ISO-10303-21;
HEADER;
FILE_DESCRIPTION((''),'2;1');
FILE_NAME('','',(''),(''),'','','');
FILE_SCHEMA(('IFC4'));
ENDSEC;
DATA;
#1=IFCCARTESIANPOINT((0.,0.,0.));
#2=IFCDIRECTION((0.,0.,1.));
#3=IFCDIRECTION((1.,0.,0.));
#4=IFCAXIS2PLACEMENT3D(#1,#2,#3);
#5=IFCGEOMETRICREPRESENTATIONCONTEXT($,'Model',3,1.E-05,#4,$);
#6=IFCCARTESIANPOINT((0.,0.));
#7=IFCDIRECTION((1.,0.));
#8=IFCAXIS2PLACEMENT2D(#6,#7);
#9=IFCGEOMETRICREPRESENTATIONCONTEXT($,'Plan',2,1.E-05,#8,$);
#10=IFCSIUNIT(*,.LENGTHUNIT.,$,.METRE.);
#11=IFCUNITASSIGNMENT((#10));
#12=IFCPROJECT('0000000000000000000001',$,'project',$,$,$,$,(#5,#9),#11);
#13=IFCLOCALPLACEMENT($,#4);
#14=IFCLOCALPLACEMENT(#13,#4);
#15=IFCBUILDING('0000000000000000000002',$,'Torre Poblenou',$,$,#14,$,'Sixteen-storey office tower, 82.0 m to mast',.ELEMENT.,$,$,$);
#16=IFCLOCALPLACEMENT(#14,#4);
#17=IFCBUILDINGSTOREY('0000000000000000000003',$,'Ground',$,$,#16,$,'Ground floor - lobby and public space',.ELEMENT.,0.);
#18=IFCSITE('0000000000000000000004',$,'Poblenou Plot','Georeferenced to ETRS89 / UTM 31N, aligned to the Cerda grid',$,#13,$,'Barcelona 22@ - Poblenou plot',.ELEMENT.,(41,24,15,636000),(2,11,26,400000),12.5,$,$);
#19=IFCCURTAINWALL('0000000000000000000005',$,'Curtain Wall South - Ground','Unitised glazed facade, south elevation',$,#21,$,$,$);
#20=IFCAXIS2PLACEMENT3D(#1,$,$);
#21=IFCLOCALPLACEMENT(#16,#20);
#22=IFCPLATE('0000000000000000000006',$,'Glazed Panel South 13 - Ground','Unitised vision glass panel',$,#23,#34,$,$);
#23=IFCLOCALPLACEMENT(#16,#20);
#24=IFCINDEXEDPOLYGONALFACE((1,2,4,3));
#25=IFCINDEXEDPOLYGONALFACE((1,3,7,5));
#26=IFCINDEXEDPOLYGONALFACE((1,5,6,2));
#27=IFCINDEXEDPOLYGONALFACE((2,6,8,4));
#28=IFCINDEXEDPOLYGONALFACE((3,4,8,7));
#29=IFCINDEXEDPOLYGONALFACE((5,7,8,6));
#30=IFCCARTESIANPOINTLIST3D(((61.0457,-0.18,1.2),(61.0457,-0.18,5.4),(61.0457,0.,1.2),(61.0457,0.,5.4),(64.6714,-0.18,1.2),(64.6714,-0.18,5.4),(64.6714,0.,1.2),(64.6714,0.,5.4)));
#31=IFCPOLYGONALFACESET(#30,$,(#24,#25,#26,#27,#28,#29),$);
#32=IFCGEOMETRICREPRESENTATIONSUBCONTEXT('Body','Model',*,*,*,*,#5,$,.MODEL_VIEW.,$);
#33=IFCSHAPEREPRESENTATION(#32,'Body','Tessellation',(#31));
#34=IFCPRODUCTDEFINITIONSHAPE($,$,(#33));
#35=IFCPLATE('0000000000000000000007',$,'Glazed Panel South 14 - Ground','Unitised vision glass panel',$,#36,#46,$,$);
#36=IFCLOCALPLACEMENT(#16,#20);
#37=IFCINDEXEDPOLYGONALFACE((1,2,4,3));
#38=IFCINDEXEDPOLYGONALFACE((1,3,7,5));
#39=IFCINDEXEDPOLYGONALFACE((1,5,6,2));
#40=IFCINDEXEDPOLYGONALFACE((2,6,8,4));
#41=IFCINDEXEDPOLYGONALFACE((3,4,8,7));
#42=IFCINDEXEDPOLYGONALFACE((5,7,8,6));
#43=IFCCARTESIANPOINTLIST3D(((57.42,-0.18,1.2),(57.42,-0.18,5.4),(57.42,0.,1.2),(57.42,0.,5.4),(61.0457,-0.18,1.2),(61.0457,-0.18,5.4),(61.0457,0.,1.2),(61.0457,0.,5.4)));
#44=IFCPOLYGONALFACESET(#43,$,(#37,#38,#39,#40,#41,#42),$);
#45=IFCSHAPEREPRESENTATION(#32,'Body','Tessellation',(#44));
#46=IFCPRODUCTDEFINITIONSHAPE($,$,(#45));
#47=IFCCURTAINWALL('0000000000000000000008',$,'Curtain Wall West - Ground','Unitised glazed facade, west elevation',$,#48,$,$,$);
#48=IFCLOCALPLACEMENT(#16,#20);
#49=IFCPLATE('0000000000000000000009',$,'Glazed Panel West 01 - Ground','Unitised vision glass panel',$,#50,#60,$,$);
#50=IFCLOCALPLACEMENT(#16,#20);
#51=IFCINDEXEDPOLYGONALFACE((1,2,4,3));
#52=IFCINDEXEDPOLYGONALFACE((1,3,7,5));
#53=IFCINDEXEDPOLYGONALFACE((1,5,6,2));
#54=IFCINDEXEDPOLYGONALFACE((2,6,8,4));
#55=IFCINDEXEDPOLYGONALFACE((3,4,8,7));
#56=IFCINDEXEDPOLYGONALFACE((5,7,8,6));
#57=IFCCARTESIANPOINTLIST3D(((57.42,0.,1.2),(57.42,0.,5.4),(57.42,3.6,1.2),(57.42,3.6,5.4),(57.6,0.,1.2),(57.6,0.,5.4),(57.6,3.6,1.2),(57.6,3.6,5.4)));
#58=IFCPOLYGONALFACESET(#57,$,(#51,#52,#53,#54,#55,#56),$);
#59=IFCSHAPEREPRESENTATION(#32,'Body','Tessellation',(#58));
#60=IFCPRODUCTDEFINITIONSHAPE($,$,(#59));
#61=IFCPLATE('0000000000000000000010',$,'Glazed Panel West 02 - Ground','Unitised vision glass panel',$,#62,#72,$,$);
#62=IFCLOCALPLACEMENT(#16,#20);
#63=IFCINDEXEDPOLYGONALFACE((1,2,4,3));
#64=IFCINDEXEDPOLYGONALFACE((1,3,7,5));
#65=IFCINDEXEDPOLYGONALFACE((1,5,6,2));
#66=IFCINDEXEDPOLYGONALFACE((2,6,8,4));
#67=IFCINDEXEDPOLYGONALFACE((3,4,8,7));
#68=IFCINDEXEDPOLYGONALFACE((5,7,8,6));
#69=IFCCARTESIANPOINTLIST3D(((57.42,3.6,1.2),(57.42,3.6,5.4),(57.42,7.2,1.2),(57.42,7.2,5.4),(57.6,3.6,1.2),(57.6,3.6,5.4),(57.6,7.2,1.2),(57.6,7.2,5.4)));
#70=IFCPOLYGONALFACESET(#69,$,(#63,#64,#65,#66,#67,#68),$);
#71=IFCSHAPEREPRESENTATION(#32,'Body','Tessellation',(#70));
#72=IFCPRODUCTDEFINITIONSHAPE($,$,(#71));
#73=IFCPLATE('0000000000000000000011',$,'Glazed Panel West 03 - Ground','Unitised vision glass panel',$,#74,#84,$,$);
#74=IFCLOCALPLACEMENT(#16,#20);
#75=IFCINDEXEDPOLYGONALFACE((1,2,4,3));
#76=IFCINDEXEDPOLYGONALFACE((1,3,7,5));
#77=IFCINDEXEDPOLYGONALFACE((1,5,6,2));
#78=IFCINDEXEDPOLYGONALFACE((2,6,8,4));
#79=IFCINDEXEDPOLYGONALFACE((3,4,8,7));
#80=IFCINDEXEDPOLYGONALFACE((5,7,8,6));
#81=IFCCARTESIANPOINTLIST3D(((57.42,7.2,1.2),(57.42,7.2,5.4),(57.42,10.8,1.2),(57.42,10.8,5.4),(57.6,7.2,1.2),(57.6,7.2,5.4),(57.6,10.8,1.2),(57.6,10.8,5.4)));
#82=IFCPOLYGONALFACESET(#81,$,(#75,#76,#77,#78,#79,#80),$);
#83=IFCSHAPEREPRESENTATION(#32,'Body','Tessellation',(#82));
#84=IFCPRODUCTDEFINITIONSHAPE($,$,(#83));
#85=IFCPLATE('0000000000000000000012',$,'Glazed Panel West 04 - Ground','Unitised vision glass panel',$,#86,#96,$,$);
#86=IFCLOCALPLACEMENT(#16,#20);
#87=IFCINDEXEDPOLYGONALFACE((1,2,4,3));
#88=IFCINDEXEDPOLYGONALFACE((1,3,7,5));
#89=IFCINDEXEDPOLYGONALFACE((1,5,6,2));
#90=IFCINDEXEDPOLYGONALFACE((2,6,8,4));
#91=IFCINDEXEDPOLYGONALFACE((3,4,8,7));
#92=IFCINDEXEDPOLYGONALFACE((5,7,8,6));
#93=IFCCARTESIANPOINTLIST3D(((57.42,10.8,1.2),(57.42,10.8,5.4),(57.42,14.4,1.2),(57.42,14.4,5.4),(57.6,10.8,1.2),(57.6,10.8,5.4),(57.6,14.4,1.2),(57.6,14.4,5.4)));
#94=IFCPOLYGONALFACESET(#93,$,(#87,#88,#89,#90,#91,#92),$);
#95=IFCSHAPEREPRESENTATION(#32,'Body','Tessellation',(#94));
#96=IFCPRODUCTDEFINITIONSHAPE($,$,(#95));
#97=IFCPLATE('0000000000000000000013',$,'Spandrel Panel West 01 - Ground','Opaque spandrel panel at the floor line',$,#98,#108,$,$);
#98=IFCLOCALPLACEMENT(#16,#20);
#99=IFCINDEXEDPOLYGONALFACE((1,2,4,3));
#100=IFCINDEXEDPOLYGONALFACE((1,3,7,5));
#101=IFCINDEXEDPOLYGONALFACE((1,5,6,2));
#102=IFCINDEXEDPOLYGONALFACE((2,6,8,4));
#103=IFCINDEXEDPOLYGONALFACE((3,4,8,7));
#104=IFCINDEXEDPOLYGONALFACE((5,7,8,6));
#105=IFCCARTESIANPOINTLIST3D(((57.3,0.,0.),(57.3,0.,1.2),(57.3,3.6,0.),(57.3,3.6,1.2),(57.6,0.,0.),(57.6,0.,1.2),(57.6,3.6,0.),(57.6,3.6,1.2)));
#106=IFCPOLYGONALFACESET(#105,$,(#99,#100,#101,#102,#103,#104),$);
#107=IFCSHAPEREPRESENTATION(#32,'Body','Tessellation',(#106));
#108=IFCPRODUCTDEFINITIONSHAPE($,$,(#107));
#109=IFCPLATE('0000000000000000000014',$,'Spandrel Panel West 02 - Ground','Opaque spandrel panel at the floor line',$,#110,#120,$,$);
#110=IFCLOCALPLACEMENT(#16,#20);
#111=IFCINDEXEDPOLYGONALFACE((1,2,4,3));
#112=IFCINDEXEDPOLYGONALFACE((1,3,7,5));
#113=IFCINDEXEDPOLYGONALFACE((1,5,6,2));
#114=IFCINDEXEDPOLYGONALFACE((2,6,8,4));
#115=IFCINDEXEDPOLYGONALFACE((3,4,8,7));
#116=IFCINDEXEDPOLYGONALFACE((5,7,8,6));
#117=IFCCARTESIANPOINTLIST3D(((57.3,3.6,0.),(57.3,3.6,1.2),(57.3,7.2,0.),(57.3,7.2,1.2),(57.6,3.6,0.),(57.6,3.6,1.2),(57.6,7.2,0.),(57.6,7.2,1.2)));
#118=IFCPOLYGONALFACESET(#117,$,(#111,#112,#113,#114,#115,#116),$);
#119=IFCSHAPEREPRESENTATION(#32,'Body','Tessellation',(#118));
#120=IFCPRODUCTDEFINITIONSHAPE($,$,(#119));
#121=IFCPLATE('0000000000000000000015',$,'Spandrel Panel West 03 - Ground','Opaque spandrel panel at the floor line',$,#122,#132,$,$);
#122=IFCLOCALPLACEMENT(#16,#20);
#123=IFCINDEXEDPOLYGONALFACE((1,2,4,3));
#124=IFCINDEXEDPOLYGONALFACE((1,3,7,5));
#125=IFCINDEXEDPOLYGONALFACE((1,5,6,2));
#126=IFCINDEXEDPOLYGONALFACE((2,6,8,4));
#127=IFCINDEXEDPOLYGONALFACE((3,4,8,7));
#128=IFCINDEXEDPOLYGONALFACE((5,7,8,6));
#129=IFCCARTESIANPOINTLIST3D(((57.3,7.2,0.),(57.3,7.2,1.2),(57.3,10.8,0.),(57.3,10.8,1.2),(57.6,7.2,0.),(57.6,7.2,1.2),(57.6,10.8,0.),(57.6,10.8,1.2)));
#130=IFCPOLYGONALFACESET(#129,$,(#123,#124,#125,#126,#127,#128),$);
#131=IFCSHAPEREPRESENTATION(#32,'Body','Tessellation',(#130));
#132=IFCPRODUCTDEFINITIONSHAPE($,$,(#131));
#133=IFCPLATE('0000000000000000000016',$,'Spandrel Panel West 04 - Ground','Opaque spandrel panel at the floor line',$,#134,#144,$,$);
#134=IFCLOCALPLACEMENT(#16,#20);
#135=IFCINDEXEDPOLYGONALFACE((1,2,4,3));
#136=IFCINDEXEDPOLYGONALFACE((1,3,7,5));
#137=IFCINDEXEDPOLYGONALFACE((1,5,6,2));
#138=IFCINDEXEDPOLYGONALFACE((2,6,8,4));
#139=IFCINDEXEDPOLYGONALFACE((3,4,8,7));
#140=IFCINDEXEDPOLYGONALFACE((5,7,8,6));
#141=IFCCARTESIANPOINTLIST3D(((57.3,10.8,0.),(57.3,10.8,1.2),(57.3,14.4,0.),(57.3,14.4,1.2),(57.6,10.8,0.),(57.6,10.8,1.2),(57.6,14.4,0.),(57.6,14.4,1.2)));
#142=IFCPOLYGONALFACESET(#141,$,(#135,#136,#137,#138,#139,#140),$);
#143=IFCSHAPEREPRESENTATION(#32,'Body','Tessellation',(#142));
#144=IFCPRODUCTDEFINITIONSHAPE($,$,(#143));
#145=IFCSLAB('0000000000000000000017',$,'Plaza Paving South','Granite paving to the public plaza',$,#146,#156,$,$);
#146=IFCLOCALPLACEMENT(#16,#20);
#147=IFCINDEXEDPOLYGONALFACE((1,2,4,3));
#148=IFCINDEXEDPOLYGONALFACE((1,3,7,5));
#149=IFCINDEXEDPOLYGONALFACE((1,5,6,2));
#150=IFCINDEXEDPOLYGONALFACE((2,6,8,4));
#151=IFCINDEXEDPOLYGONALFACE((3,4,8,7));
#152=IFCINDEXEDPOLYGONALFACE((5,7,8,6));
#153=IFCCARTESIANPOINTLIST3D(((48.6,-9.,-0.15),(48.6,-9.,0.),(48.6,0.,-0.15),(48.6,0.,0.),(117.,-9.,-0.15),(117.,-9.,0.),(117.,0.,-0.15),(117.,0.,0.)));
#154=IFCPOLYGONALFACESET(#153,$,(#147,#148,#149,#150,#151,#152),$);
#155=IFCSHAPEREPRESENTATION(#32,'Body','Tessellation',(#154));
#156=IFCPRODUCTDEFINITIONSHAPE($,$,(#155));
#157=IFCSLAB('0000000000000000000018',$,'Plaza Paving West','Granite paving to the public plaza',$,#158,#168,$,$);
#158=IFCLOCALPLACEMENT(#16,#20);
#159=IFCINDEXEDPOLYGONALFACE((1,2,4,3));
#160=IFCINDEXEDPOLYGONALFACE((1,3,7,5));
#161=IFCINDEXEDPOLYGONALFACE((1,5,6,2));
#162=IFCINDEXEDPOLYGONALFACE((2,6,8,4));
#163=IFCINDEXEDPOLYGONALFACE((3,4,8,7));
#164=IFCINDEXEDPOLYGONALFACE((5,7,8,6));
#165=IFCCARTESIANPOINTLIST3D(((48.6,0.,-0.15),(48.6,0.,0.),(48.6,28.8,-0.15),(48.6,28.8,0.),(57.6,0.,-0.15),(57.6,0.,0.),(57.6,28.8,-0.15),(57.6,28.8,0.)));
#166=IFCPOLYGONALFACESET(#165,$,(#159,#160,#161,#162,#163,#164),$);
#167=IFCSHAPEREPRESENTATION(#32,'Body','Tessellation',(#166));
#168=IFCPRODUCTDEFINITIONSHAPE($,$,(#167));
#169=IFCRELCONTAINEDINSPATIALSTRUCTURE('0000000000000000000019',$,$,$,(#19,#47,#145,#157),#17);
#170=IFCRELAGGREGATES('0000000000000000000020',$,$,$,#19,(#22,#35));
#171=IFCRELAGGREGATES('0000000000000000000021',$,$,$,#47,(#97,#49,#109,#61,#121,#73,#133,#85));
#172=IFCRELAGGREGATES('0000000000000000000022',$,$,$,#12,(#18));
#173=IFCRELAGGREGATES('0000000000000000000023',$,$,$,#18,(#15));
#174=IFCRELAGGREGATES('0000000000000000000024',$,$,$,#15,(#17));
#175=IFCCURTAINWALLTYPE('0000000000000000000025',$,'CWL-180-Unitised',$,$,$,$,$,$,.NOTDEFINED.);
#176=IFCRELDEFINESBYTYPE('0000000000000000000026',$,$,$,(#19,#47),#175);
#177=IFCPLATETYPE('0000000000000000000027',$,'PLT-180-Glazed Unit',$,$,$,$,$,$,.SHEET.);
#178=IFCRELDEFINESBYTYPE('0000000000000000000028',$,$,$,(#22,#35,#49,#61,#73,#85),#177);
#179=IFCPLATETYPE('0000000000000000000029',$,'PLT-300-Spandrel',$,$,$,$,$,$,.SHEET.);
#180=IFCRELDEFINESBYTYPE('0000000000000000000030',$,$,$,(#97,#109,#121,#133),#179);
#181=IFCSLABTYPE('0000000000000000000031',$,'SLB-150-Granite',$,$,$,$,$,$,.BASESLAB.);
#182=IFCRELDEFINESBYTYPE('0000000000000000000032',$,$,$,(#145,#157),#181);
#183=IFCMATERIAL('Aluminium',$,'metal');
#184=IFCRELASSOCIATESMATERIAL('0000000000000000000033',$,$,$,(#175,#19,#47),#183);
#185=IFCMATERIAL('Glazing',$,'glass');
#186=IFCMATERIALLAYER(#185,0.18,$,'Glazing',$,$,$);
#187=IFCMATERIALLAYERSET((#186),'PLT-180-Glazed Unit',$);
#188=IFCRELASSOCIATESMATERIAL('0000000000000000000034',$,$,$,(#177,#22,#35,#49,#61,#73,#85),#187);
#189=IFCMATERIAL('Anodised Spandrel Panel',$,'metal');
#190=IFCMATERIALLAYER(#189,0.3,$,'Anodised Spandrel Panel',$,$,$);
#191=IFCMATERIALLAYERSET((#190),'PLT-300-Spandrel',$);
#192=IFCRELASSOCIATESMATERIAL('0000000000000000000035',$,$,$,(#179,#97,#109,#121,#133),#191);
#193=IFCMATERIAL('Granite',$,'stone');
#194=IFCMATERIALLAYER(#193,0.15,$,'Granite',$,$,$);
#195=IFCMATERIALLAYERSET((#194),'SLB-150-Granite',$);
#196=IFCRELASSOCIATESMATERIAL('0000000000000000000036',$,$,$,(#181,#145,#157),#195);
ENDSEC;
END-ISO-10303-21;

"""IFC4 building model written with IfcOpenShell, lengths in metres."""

from ifc_helpers import new_model, si_unit, frame, origin_with_axes, origin_2d_with_axis, place, context, subcontext, project, spatial, line, indexed_curve, outline, extrude, material, layer, layer_set, layer_usage, type_object, element, aggregate, save


model = new_model("IFC4")

# Units and contexts
model_context = context("Model", 3, precision=1e-05, world=origin_with_axes())
plan_context = context("Plan", 2, precision=1e-05, world=origin_2d_with_axis())
body_context = subcontext(model_context, "Body", "Model", "MODEL_VIEW")
ifc_project = project(units=[si_unit("LENGTHUNIT", "METRE")], contexts=[model_context, plan_context])

# Site, building, storey
site_placement = place(None, origin_with_axes())
site = spatial("IfcSite", under=ifc_project, at=site_placement, Name="Poblenou Plot", Description="Georeferenced to ETRS89 / UTM 31N, aligned to the Cerda grid", LongName="Barcelona 22@ - Poblenou plot", CompositionType="ELEMENT", RefLatitude=(41, 24, 15, 636000), RefLongitude=(2, 11, 26, 400000), RefElevation=12.5)
building_placement = place(site_placement, origin_with_axes())
building = spatial("IfcBuilding", under=site, at=building_placement, Name="Torre Poblenou", LongName="Sixteen-storey office tower, 82.0 m to mast", CompositionType="ELEMENT")
storey_placement = place(building_placement, origin_with_axes())
storey = spatial("IfcBuildingStorey", under=building, at=storey_placement, Name="Ground", LongName="Ground floor - lobby and public space", CompositionType="ELEMENT", Elevation=0.0)

# Curtain walls, plates
ifc_material_1 = material(Name="Aluminium", Category="metal")
curtain_wall_type = type_object("IfcCurtainWallType", Name="CWL-180-Unitised", PredefinedType="NOTDEFINED", material=ifc_material_1)
curtain_wall_1_placement = place(storey_placement, frame((108.18, 0.0, 0.0), z_axis=(0.0, 0.0, 1.0), x_axis=(-1.0, 0.0, 0.0)))
curtain_wall_1 = element("IfcCurtainWall", 1, at=curtain_wall_1_placement, inside=storey, type_object=curtain_wall_type, material=ifc_material_1, Name="Curtain Wall South - Ground", Description="Unitised glazed facade, south elevation")
ifc_material_2 = material(Name="Glazing", Category="glass")
ifc_layer_1 = layer(ifc_material_2, 0.18, Name="Glazing")
ifc_layer_set_1 = layer_set([ifc_layer_1], Name="PLT-180-Glazed Unit")
plate_type_1 = type_object("IfcPlateType", Name="PLT-180-Glazed Unit", PredefinedType="SHEET", material=ifc_layer_set_1)
ifc_layer_usage_1 = layer_usage(ifc_layer_set_1, "AXIS2", "POSITIVE", 0.0)
plate_1_placement = place(curtain_wall_1_placement, frame((43.5086, 0.0, 1.2), z_axis=(0.0, 0.0, 1.0), x_axis=(1.0, 0.0, 0.0)))
plate_1 = element("IfcPlate", 2, at=plate_1_placement, type_object=plate_type_1, material=ifc_layer_usage_1, Name="Glazed Panel South 13 - Ground", Description="Unitised vision glass panel", context=body_context, shape_type="SweptSolid", body=[
    extrude(outline(indexed_curve([(0.0, 0.0), (3.6257, 0.0), (3.6257, 0.18), (0.0, 0.18)], segments=[line(1, 2, 3, 4, 1)])), origin_with_axes(), (0.0, 0.0, 1.0), 4.2),
])
ifc_layer_usage_2 = layer_usage(ifc_layer_set_1, "AXIS2", "POSITIVE", 0.0)
plate_2_placement = place(curtain_wall_1_placement, frame((47.1343, 0.0, 1.2), z_axis=(0.0, 0.0, 1.0), x_axis=(1.0, 0.0, 0.0)))
plate_2 = element("IfcPlate", 3, at=plate_2_placement, type_object=plate_type_1, material=ifc_layer_usage_2, Name="Glazed Panel South 14 - Ground", Description="Unitised vision glass panel", context=body_context, shape_type="SweptSolid", body=[
    extrude(outline(indexed_curve([(0.0, 0.0), (3.6257, 0.0), (3.6257, 0.18), (0.0, 0.18)], segments=[line(1, 2, 3, 4, 1)])), origin_with_axes(), (0.0, 0.0, 1.0), 4.2),
])
curtain_wall_2_placement = place(storey_placement, frame((57.6, 0.0, 0.0), z_axis=(0.0, 0.0, 1.0), x_axis=(0.0, 1.0, 0.0)))
curtain_wall_2 = element("IfcCurtainWall", 4, at=curtain_wall_2_placement, inside=storey, type_object=curtain_wall_type, material=ifc_material_1, Name="Curtain Wall West - Ground", Description="Unitised glazed facade, west elevation")
ifc_layer_usage_3 = layer_usage(ifc_layer_set_1, "AXIS2", "POSITIVE", 0.0)
plate_3_placement = place(curtain_wall_2_placement, frame((0.0, 0.0, 1.2), z_axis=(0.0, 0.0, 1.0), x_axis=(1.0, 0.0, 0.0)))
plate_3 = element("IfcPlate", 5, at=plate_3_placement, type_object=plate_type_1, material=ifc_layer_usage_3, Name="Glazed Panel West 01 - Ground", Description="Unitised vision glass panel", context=body_context, shape_type="SweptSolid", body=[
    extrude(outline(indexed_curve([(0.0, 0.0), (3.6, 0.0), (3.6, 0.18), (0.0, 0.18)], segments=[line(1, 2, 3, 4, 1)])), origin_with_axes(), (0.0, 0.0, 1.0), 4.2),
])
ifc_layer_usage_4 = layer_usage(ifc_layer_set_1, "AXIS2", "POSITIVE", 0.0)
plate_4_placement = place(curtain_wall_2_placement, frame((3.6, 0.0, 1.2), z_axis=(0.0, 0.0, 1.0), x_axis=(1.0, 0.0, 0.0)))
plate_4 = element("IfcPlate", 6, at=plate_4_placement, type_object=plate_type_1, material=ifc_layer_usage_4, Name="Glazed Panel West 02 - Ground", Description="Unitised vision glass panel", context=body_context, shape_type="SweptSolid", body=[
    extrude(outline(indexed_curve([(0.0, 0.0), (3.6, 0.0), (3.6, 0.18), (0.0, 0.18)], segments=[line(1, 2, 3, 4, 1)])), origin_with_axes(), (0.0, 0.0, 1.0), 4.2),
])
ifc_layer_usage_5 = layer_usage(ifc_layer_set_1, "AXIS2", "POSITIVE", 0.0)
plate_5_placement = place(curtain_wall_2_placement, frame((7.2, 0.0, 1.2), z_axis=(0.0, 0.0, 1.0), x_axis=(1.0, 0.0, 0.0)))
plate_5 = element("IfcPlate", 7, at=plate_5_placement, type_object=plate_type_1, material=ifc_layer_usage_5, Name="Glazed Panel West 03 - Ground", Description="Unitised vision glass panel", context=body_context, shape_type="SweptSolid", body=[
    extrude(outline(indexed_curve([(0.0, 0.0), (3.6, 0.0), (3.6, 0.18), (0.0, 0.18)], segments=[line(1, 2, 3, 4, 1)])), origin_with_axes(), (0.0, 0.0, 1.0), 4.2),
])
ifc_layer_usage_6 = layer_usage(ifc_layer_set_1, "AXIS2", "POSITIVE", 0.0)
plate_6_placement = place(curtain_wall_2_placement, frame((10.8, 0.0, 1.2), z_axis=(0.0, 0.0, 1.0), x_axis=(1.0, 0.0, 0.0)))
plate_6 = element("IfcPlate", 8, at=plate_6_placement, type_object=plate_type_1, material=ifc_layer_usage_6, Name="Glazed Panel West 04 - Ground", Description="Unitised vision glass panel", context=body_context, shape_type="SweptSolid", body=[
    extrude(outline(indexed_curve([(0.0, 0.0), (3.6, 0.0), (3.6, 0.18), (0.0, 0.18)], segments=[line(1, 2, 3, 4, 1)])), origin_with_axes(), (0.0, 0.0, 1.0), 4.2),
])

# Plates
ifc_material_3 = material(Name="Anodised Spandrel Panel", Category="metal")
ifc_layer_2 = layer(ifc_material_3, 0.3, Name="Anodised Spandrel Panel")
ifc_layer_set_2 = layer_set([ifc_layer_2], Name="PLT-300-Spandrel")
plate_type_2 = type_object("IfcPlateType", Name="PLT-300-Spandrel", PredefinedType="SHEET", material=ifc_layer_set_2)
aggregate(curtain_wall_1, [plate_1, plate_2])
ifc_layer_usage_7 = layer_usage(ifc_layer_set_2, "AXIS2", "POSITIVE", 0.0)
plate_7_placement = place(curtain_wall_2_placement, origin_with_axes())
plate_7 = element("IfcPlate", 9, at=plate_7_placement, type_object=plate_type_2, material=ifc_layer_usage_7, Name="Spandrel Panel West 01 - Ground", Description="Opaque spandrel panel at the floor line", context=body_context, shape_type="SweptSolid", body=[
    extrude(outline(indexed_curve([(0.0, 0.0), (3.6, 0.0), (3.6, 0.3), (0.0, 0.3)], segments=[line(1, 2, 3, 4, 1)])), origin_with_axes(), (0.0, 0.0, 1.0), 1.2),
])
ifc_layer_usage_8 = layer_usage(ifc_layer_set_2, "AXIS2", "POSITIVE", 0.0)
plate_8_placement = place(curtain_wall_2_placement, frame((3.6, 0.0, 0.0), z_axis=(0.0, 0.0, 1.0), x_axis=(1.0, 0.0, 0.0)))
plate_8 = element("IfcPlate", 10, at=plate_8_placement, type_object=plate_type_2, material=ifc_layer_usage_8, Name="Spandrel Panel West 02 - Ground", Description="Opaque spandrel panel at the floor line", context=body_context, shape_type="SweptSolid", body=[
    extrude(outline(indexed_curve([(0.0, 0.0), (3.6, 0.0), (3.6, 0.3), (0.0, 0.3)], segments=[line(1, 2, 3, 4, 1)])), origin_with_axes(), (0.0, 0.0, 1.0), 1.2),
])
ifc_layer_usage_9 = layer_usage(ifc_layer_set_2, "AXIS2", "POSITIVE", 0.0)
plate_9_placement = place(curtain_wall_2_placement, frame((7.2, 0.0, 0.0), z_axis=(0.0, 0.0, 1.0), x_axis=(1.0, 0.0, 0.0)))
plate_9 = element("IfcPlate", 11, at=plate_9_placement, type_object=plate_type_2, material=ifc_layer_usage_9, Name="Spandrel Panel West 03 - Ground", Description="Opaque spandrel panel at the floor line", context=body_context, shape_type="SweptSolid", body=[
    extrude(outline(indexed_curve([(0.0, 0.0), (3.6, 0.0), (3.6, 0.3), (0.0, 0.3)], segments=[line(1, 2, 3, 4, 1)])), origin_with_axes(), (0.0, 0.0, 1.0), 1.2),
])
ifc_layer_usage_10 = layer_usage(ifc_layer_set_2, "AXIS2", "POSITIVE", 0.0)
plate_10_placement = place(curtain_wall_2_placement, frame((10.8, 0.0, 0.0), z_axis=(0.0, 0.0, 1.0), x_axis=(1.0, 0.0, 0.0)))
plate_10 = element("IfcPlate", 12, at=plate_10_placement, type_object=plate_type_2, material=ifc_layer_usage_10, Name="Spandrel Panel West 04 - Ground", Description="Opaque spandrel panel at the floor line", context=body_context, shape_type="SweptSolid", body=[
    extrude(outline(indexed_curve([(0.0, 0.0), (3.6, 0.0), (3.6, 0.3), (0.0, 0.3)], segments=[line(1, 2, 3, 4, 1)])), origin_with_axes(), (0.0, 0.0, 1.0), 1.2),
])
aggregate(curtain_wall_2, [plate_7, plate_3, plate_8, plate_4, plate_9, plate_5, plate_10, plate_6])

# Slabs
ifc_material_4 = material(Name="Granite", Category="stone")
ifc_layer_3 = layer(ifc_material_4, 0.15, Name="Granite")
ifc_layer_set_3 = layer_set([ifc_layer_3], Name="SLB-150-Granite")
ifc_layer_usage_11 = layer_usage(ifc_layer_set_3, "AXIS3", "POSITIVE", 0.0)
slab_type_1 = type_object("IfcSlabType", Name="SLB-150-Granite", PredefinedType="BASESLAB", material=ifc_layer_set_3)
slab_1_placement = place(storey_placement, frame((48.6, -9.0, -0.15), z_axis=(0.0, 0.0, 1.0), x_axis=(1.0, 0.0, 0.0)))
element("IfcSlab", 13, at=slab_1_placement, inside=storey, type_object=slab_type_1, material=ifc_layer_usage_11, Name="Plaza Paving South", Description="Granite paving to the public plaza", context=body_context, shape_type="SweptSolid", body=[
    extrude(outline(indexed_curve([(0.0, 0.0), (68.4, 0.0), (68.4, 9.0), (0.0, 9.0)], segments=[line(1, 2, 3, 4, 1)])), origin_with_axes(), (0.0, 0.0, 1.0), 0.15),
])
ifc_layer_usage_12 = layer_usage(ifc_layer_set_3, "AXIS3", "POSITIVE", 0.0)
slab_2_placement = place(storey_placement, frame((48.6, 0.0, -0.15), z_axis=(0.0, 0.0, 1.0), x_axis=(1.0, 0.0, 0.0)))
element("IfcSlab", 14, at=slab_2_placement, inside=storey, type_object=slab_type_1, material=ifc_layer_usage_12, Name="Plaza Paving West", Description="Granite paving to the public plaza", context=body_context, shape_type="SweptSolid", body=[
    extrude(outline(indexed_curve([(0.0, 0.0), (9.0, 0.0), (9.0, 28.8), (0.0, 28.8)], segments=[line(1, 2, 3, 4, 1)])), origin_with_axes(), (0.0, 0.0, 1.0), 0.15),
])

save(model, "model.ifc")
